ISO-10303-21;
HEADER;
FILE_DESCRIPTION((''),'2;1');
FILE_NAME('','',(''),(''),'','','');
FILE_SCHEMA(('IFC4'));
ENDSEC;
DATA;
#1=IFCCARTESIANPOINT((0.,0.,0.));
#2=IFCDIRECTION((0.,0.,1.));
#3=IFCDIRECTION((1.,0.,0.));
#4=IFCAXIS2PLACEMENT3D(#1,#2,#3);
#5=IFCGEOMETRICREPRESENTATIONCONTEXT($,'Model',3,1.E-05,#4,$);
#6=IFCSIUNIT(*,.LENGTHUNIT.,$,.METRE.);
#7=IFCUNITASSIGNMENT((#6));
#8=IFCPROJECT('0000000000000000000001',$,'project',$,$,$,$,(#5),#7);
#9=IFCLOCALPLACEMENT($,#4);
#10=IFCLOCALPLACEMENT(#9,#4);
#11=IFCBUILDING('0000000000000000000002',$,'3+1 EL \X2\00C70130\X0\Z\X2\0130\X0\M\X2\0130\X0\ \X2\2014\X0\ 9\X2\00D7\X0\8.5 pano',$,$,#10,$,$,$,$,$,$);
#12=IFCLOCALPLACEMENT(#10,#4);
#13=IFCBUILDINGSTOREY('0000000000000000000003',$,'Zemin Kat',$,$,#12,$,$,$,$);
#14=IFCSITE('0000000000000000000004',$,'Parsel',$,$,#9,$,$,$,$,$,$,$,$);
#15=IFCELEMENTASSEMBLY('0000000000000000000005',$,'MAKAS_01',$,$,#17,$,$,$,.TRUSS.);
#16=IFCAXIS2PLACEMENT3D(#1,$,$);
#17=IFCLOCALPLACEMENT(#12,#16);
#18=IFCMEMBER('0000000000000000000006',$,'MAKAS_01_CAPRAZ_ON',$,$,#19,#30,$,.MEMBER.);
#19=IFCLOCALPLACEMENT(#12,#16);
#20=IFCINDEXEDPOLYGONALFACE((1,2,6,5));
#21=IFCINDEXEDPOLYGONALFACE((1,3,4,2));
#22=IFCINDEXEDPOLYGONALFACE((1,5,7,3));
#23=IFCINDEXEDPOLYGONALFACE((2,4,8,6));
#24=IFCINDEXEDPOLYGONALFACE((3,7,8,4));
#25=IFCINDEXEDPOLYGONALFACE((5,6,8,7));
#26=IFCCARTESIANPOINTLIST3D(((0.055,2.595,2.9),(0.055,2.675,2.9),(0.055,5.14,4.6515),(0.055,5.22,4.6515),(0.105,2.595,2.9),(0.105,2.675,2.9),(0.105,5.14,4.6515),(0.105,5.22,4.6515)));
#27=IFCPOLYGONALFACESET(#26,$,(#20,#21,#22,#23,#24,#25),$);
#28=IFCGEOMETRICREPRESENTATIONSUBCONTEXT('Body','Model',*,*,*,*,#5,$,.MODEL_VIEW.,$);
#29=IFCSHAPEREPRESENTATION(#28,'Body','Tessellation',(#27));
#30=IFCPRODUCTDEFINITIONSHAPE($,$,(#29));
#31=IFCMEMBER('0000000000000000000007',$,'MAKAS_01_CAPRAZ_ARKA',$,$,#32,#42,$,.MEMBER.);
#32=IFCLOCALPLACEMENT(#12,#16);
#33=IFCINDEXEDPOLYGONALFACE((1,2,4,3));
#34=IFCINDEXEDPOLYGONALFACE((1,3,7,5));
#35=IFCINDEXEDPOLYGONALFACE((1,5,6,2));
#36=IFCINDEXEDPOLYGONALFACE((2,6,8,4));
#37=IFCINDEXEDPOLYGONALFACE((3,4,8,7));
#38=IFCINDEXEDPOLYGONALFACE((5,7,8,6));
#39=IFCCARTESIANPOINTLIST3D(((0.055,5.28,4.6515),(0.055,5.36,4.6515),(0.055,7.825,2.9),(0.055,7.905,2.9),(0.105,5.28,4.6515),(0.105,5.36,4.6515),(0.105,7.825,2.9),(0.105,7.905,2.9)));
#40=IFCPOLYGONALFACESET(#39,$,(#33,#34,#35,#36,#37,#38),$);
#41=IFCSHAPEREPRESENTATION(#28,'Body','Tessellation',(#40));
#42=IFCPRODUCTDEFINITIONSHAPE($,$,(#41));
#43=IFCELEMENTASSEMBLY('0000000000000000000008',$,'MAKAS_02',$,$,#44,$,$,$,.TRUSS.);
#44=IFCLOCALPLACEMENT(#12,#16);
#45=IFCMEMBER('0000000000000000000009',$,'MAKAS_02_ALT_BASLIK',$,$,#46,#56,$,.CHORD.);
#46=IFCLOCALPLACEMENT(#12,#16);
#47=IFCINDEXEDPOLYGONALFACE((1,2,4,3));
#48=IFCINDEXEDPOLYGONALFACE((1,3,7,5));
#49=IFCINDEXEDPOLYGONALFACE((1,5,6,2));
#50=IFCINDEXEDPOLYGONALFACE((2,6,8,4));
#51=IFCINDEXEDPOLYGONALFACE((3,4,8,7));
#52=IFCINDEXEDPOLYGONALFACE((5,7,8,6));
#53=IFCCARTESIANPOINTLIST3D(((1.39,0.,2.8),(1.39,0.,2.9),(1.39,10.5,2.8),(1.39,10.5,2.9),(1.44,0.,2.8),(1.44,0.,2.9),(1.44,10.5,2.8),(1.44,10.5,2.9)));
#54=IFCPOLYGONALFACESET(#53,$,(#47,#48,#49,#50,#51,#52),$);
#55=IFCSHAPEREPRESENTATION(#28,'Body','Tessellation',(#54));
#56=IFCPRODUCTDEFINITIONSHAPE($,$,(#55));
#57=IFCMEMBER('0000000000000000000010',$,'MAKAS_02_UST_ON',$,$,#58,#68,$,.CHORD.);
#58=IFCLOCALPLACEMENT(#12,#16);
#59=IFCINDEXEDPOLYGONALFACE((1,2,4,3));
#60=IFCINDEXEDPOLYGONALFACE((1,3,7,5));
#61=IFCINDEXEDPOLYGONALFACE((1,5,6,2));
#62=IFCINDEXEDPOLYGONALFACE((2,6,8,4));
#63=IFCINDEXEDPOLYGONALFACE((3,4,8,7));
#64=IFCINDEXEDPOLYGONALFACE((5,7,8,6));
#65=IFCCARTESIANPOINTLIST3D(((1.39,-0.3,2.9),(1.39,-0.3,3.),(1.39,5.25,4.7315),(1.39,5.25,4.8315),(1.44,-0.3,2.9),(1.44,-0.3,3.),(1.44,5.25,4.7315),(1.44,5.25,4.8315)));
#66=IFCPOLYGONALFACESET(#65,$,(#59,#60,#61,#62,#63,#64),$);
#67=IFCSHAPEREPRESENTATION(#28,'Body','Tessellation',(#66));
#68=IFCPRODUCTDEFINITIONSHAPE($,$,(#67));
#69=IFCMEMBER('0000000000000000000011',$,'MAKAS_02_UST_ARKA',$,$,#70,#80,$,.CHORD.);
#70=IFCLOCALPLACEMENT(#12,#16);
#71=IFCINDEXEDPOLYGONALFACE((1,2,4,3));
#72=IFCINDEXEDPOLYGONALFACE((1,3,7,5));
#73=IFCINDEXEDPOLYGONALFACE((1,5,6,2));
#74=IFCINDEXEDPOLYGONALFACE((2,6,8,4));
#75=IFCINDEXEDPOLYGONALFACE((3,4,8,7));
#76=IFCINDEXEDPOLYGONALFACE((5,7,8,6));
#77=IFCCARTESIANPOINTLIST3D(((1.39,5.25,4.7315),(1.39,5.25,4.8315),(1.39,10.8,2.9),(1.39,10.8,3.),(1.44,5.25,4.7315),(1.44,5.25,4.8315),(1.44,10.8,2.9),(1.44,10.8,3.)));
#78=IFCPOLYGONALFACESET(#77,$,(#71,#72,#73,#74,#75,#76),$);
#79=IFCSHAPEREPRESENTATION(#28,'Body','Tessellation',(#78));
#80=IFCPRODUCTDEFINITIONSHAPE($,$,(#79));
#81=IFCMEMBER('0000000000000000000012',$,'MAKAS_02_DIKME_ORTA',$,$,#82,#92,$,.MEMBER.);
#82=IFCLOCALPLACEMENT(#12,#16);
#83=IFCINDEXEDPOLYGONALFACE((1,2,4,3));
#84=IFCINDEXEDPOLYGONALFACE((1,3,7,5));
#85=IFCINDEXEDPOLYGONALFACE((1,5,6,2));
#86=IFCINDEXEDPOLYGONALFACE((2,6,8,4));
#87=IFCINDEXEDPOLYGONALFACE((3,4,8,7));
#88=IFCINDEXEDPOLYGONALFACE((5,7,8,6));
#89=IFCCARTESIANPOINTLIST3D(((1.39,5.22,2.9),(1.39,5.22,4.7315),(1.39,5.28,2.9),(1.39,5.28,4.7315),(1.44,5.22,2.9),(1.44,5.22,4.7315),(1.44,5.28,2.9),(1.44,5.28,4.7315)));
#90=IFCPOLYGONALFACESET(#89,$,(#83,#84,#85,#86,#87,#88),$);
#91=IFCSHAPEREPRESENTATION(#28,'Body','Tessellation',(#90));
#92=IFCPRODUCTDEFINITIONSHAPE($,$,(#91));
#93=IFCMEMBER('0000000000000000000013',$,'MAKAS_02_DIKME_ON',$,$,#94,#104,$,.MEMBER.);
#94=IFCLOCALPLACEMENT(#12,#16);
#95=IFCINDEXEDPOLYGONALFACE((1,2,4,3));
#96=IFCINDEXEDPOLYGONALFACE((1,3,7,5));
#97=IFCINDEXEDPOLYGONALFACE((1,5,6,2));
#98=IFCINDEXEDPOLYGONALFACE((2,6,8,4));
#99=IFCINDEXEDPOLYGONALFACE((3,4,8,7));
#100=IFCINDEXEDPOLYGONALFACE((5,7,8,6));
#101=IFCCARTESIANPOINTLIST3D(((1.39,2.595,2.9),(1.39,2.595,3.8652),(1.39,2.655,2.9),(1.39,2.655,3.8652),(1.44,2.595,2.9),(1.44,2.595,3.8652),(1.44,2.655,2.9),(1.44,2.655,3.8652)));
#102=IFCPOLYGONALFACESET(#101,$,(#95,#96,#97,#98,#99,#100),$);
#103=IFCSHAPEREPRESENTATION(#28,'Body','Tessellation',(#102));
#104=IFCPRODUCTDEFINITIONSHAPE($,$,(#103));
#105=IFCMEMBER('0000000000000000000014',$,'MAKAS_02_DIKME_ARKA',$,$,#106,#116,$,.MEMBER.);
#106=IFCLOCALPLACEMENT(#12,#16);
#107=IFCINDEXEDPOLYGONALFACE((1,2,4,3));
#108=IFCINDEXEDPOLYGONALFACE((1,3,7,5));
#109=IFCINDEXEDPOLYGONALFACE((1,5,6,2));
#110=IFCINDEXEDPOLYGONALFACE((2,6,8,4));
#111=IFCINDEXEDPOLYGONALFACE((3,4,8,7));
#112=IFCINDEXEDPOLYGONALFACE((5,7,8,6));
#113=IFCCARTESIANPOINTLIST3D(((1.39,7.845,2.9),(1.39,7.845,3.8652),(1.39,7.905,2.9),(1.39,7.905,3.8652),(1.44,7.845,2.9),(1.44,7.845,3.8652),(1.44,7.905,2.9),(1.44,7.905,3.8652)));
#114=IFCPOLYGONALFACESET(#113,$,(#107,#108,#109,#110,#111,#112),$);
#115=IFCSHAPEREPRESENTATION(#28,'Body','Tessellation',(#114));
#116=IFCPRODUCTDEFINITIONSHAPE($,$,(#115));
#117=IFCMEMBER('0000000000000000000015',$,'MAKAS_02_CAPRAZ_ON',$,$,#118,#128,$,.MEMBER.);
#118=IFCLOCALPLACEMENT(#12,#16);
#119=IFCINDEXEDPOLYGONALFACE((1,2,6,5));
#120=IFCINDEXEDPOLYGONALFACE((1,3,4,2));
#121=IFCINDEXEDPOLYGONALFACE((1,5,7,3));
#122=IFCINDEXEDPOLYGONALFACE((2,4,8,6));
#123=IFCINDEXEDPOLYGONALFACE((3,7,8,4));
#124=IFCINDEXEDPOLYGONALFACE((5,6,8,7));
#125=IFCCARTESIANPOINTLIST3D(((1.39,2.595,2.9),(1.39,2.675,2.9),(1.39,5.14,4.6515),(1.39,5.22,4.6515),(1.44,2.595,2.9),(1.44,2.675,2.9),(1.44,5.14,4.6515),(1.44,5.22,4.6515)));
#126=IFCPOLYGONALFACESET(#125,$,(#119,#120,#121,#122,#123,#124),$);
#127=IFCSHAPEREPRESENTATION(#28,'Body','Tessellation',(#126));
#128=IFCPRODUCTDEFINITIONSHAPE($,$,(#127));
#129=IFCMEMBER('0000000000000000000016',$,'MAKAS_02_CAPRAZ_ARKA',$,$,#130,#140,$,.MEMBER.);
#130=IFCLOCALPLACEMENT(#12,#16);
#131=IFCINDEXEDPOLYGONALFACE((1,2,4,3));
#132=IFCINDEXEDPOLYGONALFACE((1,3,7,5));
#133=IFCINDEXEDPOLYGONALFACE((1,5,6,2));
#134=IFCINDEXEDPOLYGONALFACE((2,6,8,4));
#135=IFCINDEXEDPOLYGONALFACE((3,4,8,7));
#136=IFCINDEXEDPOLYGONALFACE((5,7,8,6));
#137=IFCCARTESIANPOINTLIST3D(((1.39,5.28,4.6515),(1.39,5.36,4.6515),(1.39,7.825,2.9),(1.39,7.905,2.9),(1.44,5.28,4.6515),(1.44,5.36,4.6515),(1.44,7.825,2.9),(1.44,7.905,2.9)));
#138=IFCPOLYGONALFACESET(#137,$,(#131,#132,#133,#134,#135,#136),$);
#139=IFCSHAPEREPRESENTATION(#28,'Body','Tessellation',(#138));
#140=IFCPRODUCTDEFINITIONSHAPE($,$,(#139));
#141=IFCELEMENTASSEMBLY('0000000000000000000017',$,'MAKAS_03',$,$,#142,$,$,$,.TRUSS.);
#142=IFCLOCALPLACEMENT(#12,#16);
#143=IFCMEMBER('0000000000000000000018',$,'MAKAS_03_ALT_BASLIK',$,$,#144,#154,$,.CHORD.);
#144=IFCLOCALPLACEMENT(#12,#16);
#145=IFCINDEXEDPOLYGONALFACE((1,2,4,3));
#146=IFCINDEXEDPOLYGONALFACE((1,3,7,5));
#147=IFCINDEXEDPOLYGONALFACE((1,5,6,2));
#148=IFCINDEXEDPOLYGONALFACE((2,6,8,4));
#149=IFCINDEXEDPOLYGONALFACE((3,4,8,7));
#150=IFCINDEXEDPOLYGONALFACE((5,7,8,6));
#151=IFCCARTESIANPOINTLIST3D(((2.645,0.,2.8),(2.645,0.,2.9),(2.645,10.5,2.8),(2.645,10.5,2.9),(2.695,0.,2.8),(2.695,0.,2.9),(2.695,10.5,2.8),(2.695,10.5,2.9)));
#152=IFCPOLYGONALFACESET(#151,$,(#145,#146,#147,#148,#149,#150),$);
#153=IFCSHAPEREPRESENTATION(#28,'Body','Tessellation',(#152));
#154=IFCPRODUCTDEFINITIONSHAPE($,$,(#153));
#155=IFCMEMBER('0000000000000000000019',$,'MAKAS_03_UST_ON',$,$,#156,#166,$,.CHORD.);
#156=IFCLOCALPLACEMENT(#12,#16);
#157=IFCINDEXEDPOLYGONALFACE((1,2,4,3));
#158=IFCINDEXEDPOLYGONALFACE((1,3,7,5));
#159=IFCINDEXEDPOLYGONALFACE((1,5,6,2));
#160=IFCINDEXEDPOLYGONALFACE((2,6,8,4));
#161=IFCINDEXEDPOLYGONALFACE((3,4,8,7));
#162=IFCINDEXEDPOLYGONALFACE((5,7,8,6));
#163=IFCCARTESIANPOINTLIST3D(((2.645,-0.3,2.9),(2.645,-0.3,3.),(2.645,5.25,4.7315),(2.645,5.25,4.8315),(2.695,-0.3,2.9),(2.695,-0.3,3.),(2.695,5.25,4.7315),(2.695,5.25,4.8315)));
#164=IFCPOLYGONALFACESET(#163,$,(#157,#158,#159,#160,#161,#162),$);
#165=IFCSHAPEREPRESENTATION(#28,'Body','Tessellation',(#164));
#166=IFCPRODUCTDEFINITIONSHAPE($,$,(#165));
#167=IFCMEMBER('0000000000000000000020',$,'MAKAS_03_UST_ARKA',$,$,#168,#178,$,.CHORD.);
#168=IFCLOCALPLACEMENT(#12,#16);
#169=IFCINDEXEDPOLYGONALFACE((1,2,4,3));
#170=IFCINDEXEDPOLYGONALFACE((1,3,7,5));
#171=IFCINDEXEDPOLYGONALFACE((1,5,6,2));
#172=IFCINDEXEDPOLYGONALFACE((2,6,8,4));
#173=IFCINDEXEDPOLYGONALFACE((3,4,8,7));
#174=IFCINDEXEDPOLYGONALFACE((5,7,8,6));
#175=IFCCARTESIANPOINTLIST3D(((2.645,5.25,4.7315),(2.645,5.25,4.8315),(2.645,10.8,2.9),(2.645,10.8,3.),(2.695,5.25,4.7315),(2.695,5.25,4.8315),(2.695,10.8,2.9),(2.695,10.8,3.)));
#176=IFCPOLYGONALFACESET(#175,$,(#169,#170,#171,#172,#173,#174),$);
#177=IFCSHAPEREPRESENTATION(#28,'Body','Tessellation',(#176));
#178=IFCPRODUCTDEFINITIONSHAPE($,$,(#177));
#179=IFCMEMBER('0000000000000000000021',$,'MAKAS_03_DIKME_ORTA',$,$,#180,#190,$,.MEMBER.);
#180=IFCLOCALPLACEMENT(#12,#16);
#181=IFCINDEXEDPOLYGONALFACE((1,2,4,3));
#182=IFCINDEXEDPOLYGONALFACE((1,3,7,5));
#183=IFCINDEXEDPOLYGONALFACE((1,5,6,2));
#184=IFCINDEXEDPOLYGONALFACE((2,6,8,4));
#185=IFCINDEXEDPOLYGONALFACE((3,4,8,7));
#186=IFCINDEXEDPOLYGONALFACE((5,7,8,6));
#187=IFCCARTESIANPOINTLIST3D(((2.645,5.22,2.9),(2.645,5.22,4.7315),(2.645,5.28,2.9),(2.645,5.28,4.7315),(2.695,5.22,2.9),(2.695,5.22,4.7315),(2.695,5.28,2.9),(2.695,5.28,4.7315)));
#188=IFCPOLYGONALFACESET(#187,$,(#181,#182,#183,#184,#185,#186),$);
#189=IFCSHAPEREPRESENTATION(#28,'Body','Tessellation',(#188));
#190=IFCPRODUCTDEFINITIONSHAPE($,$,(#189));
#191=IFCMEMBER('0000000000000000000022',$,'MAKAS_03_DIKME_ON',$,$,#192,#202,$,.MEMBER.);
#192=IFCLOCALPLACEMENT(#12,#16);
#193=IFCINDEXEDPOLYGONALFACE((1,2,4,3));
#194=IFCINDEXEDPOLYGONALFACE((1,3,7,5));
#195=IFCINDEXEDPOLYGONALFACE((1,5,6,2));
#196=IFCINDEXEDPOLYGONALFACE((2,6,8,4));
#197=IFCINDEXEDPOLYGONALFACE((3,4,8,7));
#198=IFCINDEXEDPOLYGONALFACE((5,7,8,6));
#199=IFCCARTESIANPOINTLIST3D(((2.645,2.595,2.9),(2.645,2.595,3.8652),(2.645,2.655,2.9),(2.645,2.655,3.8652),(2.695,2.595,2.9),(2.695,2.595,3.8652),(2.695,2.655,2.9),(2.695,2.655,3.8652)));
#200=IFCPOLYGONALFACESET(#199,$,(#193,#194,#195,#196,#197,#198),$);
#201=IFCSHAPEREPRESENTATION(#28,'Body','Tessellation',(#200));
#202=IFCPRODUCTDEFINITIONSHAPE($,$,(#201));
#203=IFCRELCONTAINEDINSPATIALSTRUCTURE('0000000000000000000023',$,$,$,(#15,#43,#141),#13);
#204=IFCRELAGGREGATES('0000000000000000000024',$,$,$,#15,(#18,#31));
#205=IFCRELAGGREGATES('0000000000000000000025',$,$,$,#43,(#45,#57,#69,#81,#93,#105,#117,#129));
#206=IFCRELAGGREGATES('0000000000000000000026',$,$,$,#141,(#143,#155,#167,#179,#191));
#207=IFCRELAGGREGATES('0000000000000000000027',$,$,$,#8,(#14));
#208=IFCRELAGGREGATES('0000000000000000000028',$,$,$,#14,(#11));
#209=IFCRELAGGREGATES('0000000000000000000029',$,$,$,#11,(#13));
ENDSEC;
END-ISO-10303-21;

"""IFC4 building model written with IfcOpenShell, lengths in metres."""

from ifc_helpers import new_model, si_unit, frame, origin_with_axes, place, context, subcontext, project, spatial, line, indexed_curve, outline, extrude, element, aggregate, save


model = new_model("IFC4")

# Units and contexts
model_context = context("Model", 3, precision=1e-05, world=origin_with_axes())
body_context = subcontext(model_context, "Body", "Model", "MODEL_VIEW")
ifc_project = project(units=[si_unit("LENGTHUNIT", "METRE")], contexts=[model_context])

# Site, building, storey
site_placement = place(None, origin_with_axes())
site = spatial("IfcSite", under=ifc_project, at=site_placement, Name="Parsel")
building_placement = place(site_placement, origin_with_axes())
building = spatial("IfcBuilding", under=site, at=building_placement, Name="3+1 EL ÇİZİMİ — 9×8.5 pano")
storey_placement = place(building_placement, origin_with_axes())
storey = spatial("IfcBuildingStorey", under=building, at=storey_placement, Name="Zemin Kat")

# Element assemblies, members
assembly_1_placement = place(storey_placement, origin_with_axes())
assembly_1 = element("IfcElementAssembly", 1, at=assembly_1_placement, inside=storey, Name="MAKAS_01", PredefinedType="TRUSS")
member_1_placement = place(assembly_1_placement, origin_with_axes())
member_1 = element("IfcMember", 2, at=member_1_placement, Name="MAKAS_01_CAPRAZ_ON", PredefinedType="MEMBER", context=body_context, shape_type="SweptSolid", body=[
    extrude(outline(indexed_curve([(2.595, 2.9), (2.675, 2.9), (5.22, 4.6515), (5.14, 4.6515)], segments=[line(1, 2, 3, 4, 1)])), frame((0.055, 0.0, 0.0), z_axis=(1.0, 0.0, 0.0), x_axis=(0.0, 1.0, 0.0)), (0.0, 0.0, 1.0), 0.05),
])
member_2_placement = place(assembly_1_placement, origin_with_axes())
member_2 = element("IfcMember", 3, at=member_2_placement, Name="MAKAS_01_CAPRAZ_ARKA", PredefinedType="MEMBER", context=body_context, shape_type="SweptSolid", body=[
    extrude(outline(indexed_curve([(7.825, 2.9), (7.905, 2.9), (5.36, 4.6515), (5.28, 4.6515)], segments=[line(1, 2, 3, 4, 1)])), frame((0.055, 0.0, 0.0), z_axis=(1.0, 0.0, 0.0), x_axis=(0.0, 1.0, 0.0)), (0.0, 0.0, 1.0), 0.05),
])
aggregate(assembly_1, [member_1, member_2])
assembly_2_placement = place(storey_placement, origin_with_axes())
assembly_2 = element("IfcElementAssembly", 4, at=assembly_2_placement, inside=storey, Name="MAKAS_02", PredefinedType="TRUSS")
member_3_placement = place(assembly_2_placement, origin_with_axes())
member_3 = element("IfcMember", 5, at=member_3_placement, Name="MAKAS_02_ALT_BASLIK", PredefinedType="CHORD", context=body_context, shape_type="SweptSolid", body=[
    extrude(outline(indexed_curve([(0.0, 2.8), (10.5, 2.8), (10.5, 2.9), (0.0, 2.9)], segments=[line(1, 2, 3, 4, 1)])), frame((1.39, 0.0, 0.0), z_axis=(1.0, 0.0, 0.0), x_axis=(0.0, 1.0, 0.0)), (0.0, 0.0, 1.0), 0.05),
])
member_4_placement = place(assembly_2_placement, origin_with_axes())
member_4 = element("IfcMember", 6, at=member_4_placement, Name="MAKAS_02_UST_ON", PredefinedType="CHORD", context=body_context, shape_type="SweptSolid", body=[
    extrude(outline(indexed_curve([(-0.3, 2.9), (5.25, 4.7315), (5.25, 4.8315), (-0.3, 3.0)], segments=[line(1, 2, 3, 4, 1)])), frame((1.39, 0.0, 0.0), z_axis=(1.0, 0.0, 0.0), x_axis=(0.0, 1.0, 0.0)), (0.0, 0.0, 1.0), 0.05),
])
member_5_placement = place(assembly_2_placement, origin_with_axes())
member_5 = element("IfcMember", 7, at=member_5_placement, Name="MAKAS_02_UST_ARKA", PredefinedType="CHORD", context=body_context, shape_type="SweptSolid", body=[
    extrude(outline(indexed_curve([(5.25, 4.7315), (10.8, 2.9), (10.8, 3.0), (5.25, 4.8315)], segments=[line(1, 2, 3, 4, 1)])), frame((1.39, 0.0, 0.0), z_axis=(1.0, 0.0, 0.0), x_axis=(0.0, 1.0, 0.0)), (0.0, 0.0, 1.0), 0.05),
])
member_6_placement = place(assembly_2_placement, origin_with_axes())
member_6 = element("IfcMember", 8, at=member_6_placement, Name="MAKAS_02_DIKME_ORTA", PredefinedType="MEMBER", context=body_context, shape_type="SweptSolid", body=[
    extrude(outline(indexed_curve([(5.22, 2.9), (5.28, 2.9), (5.28, 4.7315), (5.22, 4.7315)], segments=[line(1, 2, 3, 4, 1)])), frame((1.39, 0.0, 0.0), z_axis=(1.0, 0.0, 0.0), x_axis=(0.0, 1.0, 0.0)), (0.0, 0.0, 1.0), 0.05),
])
member_7_placement = place(assembly_2_placement, origin_with_axes())
member_7 = element("IfcMember", 9, at=member_7_placement, Name="MAKAS_02_DIKME_ON", PredefinedType="MEMBER", context=body_context, shape_type="SweptSolid", body=[
    extrude(outline(indexed_curve([(2.595, 2.9), (2.655, 2.9), (2.655, 3.8653), (2.595, 3.8653)], segments=[line(1, 2, 3, 4, 1)])), frame((1.39, 0.0, 0.0), z_axis=(1.0, 0.0, 0.0), x_axis=(0.0, 1.0, 0.0)), (0.0, 0.0, 1.0), 0.05),
])
member_8_placement = place(assembly_2_placement, origin_with_axes())
member_8 = element("IfcMember", 10, at=member_8_placement, Name="MAKAS_02_DIKME_ARKA", PredefinedType="MEMBER", context=body_context, shape_type="SweptSolid", body=[
    extrude(outline(indexed_curve([(7.845, 2.9), (7.905, 2.9), (7.905, 3.8653), (7.845, 3.8653)], segments=[line(1, 2, 3, 4, 1)])), frame((1.39, 0.0, 0.0), z_axis=(1.0, 0.0, 0.0), x_axis=(0.0, 1.0, 0.0)), (0.0, 0.0, 1.0), 0.05),
])
member_9_placement = place(assembly_2_placement, origin_with_axes())
member_9 = element("IfcMember", 11, at=member_9_placement, Name="MAKAS_02_CAPRAZ_ON", PredefinedType="MEMBER", context=body_context, shape_type="SweptSolid", body=[
    extrude(outline(indexed_curve([(2.595, 2.9), (2.675, 2.9), (5.22, 4.6515), (5.14, 4.6515)], segments=[line(1, 2, 3, 4, 1)])), frame((1.39, 0.0, 0.0), z_axis=(1.0, 0.0, 0.0), x_axis=(0.0, 1.0, 0.0)), (0.0, 0.0, 1.0), 0.05),
])
member_10_placement = place(assembly_2_placement, origin_with_axes())
member_10 = element("IfcMember", 12, at=member_10_placement, Name="MAKAS_02_CAPRAZ_ARKA", PredefinedType="MEMBER", context=body_context, shape_type="SweptSolid", body=[
    extrude(outline(indexed_curve([(7.825, 2.9), (7.905, 2.9), (5.36, 4.6515), (5.28, 4.6515)], segments=[line(1, 2, 3, 4, 1)])), frame((1.39, 0.0, 0.0), z_axis=(1.0, 0.0, 0.0), x_axis=(0.0, 1.0, 0.0)), (0.0, 0.0, 1.0), 0.05),
])
aggregate(assembly_2, [member_3, member_4, member_5, member_6, member_7, member_8, member_9, member_10])
assembly_3_placement = place(storey_placement, origin_with_axes())
assembly_3 = element("IfcElementAssembly", 13, at=assembly_3_placement, inside=storey, Name="MAKAS_03", PredefinedType="TRUSS")
member_11_placement = place(assembly_3_placement, origin_with_axes())
member_11 = element("IfcMember", 14, at=member_11_placement, Name="MAKAS_03_ALT_BASLIK", PredefinedType="CHORD", context=body_context, shape_type="SweptSolid", body=[
    extrude(outline(indexed_curve([(0.0, 2.8), (10.5, 2.8), (10.5, 2.9), (0.0, 2.9)], segments=[line(1, 2, 3, 4, 1)])), frame((2.645, 0.0, 0.0), z_axis=(1.0, 0.0, 0.0), x_axis=(0.0, 1.0, 0.0)), (0.0, 0.0, 1.0), 0.05),
])
member_12_placement = place(assembly_3_placement, origin_with_axes())
member_12 = element("IfcMember", 15, at=member_12_placement, Name="MAKAS_03_UST_ON", PredefinedType="CHORD", context=body_context, shape_type="SweptSolid", body=[
    extrude(outline(indexed_curve([(-0.3, 2.9), (5.25, 4.7315), (5.25, 4.8315), (-0.3, 3.0)], segments=[line(1, 2, 3, 4, 1)])), frame((2.645, 0.0, 0.0), z_axis=(1.0, 0.0, 0.0), x_axis=(0.0, 1.0, 0.0)), (0.0, 0.0, 1.0), 0.05),
])
member_13_placement = place(assembly_3_placement, origin_with_axes())
member_13 = element("IfcMember", 16, at=member_13_placement, Name="MAKAS_03_UST_ARKA", PredefinedType="CHORD", context=body_context, shape_type="SweptSolid", body=[
    extrude(outline(indexed_curve([(5.25, 4.7315), (10.8, 2.9), (10.8, 3.0), (5.25, 4.8315)], segments=[line(1, 2, 3, 4, 1)])), frame((2.645, 0.0, 0.0), z_axis=(1.0, 0.0, 0.0), x_axis=(0.0, 1.0, 0.0)), (0.0, 0.0, 1.0), 0.05),
])
member_14_placement = place(assembly_3_placement, origin_with_axes())
member_14 = element("IfcMember", 17, at=member_14_placement, Name="MAKAS_03_DIKME_ORTA", PredefinedType="MEMBER", context=body_context, shape_type="SweptSolid", body=[
    extrude(outline(indexed_curve([(5.22, 2.9), (5.28, 2.9), (5.28, 4.7315), (5.22, 4.7315)], segments=[line(1, 2, 3, 4, 1)])), frame((2.645, 0.0, 0.0), z_axis=(1.0, 0.0, 0.0), x_axis=(0.0, 1.0, 0.0)), (0.0, 0.0, 1.0), 0.05),
])
member_15_placement = place(assembly_3_placement, origin_with_axes())
member_15 = element("IfcMember", 18, at=member_15_placement, Name="MAKAS_03_DIKME_ON", PredefinedType="MEMBER", context=body_context, shape_type="SweptSolid", body=[
    extrude(outline(indexed_curve([(2.595, 2.9), (2.655, 2.9), (2.655, 3.8653), (2.595, 3.8653)], segments=[line(1, 2, 3, 4, 1)])), frame((2.645, 0.0, 0.0), z_axis=(1.0, 0.0, 0.0), x_axis=(0.0, 1.0, 0.0)), (0.0, 0.0, 1.0), 0.05),
])
aggregate(assembly_3, [member_11, member_12, member_13, member_14, member_15])

save(model, "model.ifc")
